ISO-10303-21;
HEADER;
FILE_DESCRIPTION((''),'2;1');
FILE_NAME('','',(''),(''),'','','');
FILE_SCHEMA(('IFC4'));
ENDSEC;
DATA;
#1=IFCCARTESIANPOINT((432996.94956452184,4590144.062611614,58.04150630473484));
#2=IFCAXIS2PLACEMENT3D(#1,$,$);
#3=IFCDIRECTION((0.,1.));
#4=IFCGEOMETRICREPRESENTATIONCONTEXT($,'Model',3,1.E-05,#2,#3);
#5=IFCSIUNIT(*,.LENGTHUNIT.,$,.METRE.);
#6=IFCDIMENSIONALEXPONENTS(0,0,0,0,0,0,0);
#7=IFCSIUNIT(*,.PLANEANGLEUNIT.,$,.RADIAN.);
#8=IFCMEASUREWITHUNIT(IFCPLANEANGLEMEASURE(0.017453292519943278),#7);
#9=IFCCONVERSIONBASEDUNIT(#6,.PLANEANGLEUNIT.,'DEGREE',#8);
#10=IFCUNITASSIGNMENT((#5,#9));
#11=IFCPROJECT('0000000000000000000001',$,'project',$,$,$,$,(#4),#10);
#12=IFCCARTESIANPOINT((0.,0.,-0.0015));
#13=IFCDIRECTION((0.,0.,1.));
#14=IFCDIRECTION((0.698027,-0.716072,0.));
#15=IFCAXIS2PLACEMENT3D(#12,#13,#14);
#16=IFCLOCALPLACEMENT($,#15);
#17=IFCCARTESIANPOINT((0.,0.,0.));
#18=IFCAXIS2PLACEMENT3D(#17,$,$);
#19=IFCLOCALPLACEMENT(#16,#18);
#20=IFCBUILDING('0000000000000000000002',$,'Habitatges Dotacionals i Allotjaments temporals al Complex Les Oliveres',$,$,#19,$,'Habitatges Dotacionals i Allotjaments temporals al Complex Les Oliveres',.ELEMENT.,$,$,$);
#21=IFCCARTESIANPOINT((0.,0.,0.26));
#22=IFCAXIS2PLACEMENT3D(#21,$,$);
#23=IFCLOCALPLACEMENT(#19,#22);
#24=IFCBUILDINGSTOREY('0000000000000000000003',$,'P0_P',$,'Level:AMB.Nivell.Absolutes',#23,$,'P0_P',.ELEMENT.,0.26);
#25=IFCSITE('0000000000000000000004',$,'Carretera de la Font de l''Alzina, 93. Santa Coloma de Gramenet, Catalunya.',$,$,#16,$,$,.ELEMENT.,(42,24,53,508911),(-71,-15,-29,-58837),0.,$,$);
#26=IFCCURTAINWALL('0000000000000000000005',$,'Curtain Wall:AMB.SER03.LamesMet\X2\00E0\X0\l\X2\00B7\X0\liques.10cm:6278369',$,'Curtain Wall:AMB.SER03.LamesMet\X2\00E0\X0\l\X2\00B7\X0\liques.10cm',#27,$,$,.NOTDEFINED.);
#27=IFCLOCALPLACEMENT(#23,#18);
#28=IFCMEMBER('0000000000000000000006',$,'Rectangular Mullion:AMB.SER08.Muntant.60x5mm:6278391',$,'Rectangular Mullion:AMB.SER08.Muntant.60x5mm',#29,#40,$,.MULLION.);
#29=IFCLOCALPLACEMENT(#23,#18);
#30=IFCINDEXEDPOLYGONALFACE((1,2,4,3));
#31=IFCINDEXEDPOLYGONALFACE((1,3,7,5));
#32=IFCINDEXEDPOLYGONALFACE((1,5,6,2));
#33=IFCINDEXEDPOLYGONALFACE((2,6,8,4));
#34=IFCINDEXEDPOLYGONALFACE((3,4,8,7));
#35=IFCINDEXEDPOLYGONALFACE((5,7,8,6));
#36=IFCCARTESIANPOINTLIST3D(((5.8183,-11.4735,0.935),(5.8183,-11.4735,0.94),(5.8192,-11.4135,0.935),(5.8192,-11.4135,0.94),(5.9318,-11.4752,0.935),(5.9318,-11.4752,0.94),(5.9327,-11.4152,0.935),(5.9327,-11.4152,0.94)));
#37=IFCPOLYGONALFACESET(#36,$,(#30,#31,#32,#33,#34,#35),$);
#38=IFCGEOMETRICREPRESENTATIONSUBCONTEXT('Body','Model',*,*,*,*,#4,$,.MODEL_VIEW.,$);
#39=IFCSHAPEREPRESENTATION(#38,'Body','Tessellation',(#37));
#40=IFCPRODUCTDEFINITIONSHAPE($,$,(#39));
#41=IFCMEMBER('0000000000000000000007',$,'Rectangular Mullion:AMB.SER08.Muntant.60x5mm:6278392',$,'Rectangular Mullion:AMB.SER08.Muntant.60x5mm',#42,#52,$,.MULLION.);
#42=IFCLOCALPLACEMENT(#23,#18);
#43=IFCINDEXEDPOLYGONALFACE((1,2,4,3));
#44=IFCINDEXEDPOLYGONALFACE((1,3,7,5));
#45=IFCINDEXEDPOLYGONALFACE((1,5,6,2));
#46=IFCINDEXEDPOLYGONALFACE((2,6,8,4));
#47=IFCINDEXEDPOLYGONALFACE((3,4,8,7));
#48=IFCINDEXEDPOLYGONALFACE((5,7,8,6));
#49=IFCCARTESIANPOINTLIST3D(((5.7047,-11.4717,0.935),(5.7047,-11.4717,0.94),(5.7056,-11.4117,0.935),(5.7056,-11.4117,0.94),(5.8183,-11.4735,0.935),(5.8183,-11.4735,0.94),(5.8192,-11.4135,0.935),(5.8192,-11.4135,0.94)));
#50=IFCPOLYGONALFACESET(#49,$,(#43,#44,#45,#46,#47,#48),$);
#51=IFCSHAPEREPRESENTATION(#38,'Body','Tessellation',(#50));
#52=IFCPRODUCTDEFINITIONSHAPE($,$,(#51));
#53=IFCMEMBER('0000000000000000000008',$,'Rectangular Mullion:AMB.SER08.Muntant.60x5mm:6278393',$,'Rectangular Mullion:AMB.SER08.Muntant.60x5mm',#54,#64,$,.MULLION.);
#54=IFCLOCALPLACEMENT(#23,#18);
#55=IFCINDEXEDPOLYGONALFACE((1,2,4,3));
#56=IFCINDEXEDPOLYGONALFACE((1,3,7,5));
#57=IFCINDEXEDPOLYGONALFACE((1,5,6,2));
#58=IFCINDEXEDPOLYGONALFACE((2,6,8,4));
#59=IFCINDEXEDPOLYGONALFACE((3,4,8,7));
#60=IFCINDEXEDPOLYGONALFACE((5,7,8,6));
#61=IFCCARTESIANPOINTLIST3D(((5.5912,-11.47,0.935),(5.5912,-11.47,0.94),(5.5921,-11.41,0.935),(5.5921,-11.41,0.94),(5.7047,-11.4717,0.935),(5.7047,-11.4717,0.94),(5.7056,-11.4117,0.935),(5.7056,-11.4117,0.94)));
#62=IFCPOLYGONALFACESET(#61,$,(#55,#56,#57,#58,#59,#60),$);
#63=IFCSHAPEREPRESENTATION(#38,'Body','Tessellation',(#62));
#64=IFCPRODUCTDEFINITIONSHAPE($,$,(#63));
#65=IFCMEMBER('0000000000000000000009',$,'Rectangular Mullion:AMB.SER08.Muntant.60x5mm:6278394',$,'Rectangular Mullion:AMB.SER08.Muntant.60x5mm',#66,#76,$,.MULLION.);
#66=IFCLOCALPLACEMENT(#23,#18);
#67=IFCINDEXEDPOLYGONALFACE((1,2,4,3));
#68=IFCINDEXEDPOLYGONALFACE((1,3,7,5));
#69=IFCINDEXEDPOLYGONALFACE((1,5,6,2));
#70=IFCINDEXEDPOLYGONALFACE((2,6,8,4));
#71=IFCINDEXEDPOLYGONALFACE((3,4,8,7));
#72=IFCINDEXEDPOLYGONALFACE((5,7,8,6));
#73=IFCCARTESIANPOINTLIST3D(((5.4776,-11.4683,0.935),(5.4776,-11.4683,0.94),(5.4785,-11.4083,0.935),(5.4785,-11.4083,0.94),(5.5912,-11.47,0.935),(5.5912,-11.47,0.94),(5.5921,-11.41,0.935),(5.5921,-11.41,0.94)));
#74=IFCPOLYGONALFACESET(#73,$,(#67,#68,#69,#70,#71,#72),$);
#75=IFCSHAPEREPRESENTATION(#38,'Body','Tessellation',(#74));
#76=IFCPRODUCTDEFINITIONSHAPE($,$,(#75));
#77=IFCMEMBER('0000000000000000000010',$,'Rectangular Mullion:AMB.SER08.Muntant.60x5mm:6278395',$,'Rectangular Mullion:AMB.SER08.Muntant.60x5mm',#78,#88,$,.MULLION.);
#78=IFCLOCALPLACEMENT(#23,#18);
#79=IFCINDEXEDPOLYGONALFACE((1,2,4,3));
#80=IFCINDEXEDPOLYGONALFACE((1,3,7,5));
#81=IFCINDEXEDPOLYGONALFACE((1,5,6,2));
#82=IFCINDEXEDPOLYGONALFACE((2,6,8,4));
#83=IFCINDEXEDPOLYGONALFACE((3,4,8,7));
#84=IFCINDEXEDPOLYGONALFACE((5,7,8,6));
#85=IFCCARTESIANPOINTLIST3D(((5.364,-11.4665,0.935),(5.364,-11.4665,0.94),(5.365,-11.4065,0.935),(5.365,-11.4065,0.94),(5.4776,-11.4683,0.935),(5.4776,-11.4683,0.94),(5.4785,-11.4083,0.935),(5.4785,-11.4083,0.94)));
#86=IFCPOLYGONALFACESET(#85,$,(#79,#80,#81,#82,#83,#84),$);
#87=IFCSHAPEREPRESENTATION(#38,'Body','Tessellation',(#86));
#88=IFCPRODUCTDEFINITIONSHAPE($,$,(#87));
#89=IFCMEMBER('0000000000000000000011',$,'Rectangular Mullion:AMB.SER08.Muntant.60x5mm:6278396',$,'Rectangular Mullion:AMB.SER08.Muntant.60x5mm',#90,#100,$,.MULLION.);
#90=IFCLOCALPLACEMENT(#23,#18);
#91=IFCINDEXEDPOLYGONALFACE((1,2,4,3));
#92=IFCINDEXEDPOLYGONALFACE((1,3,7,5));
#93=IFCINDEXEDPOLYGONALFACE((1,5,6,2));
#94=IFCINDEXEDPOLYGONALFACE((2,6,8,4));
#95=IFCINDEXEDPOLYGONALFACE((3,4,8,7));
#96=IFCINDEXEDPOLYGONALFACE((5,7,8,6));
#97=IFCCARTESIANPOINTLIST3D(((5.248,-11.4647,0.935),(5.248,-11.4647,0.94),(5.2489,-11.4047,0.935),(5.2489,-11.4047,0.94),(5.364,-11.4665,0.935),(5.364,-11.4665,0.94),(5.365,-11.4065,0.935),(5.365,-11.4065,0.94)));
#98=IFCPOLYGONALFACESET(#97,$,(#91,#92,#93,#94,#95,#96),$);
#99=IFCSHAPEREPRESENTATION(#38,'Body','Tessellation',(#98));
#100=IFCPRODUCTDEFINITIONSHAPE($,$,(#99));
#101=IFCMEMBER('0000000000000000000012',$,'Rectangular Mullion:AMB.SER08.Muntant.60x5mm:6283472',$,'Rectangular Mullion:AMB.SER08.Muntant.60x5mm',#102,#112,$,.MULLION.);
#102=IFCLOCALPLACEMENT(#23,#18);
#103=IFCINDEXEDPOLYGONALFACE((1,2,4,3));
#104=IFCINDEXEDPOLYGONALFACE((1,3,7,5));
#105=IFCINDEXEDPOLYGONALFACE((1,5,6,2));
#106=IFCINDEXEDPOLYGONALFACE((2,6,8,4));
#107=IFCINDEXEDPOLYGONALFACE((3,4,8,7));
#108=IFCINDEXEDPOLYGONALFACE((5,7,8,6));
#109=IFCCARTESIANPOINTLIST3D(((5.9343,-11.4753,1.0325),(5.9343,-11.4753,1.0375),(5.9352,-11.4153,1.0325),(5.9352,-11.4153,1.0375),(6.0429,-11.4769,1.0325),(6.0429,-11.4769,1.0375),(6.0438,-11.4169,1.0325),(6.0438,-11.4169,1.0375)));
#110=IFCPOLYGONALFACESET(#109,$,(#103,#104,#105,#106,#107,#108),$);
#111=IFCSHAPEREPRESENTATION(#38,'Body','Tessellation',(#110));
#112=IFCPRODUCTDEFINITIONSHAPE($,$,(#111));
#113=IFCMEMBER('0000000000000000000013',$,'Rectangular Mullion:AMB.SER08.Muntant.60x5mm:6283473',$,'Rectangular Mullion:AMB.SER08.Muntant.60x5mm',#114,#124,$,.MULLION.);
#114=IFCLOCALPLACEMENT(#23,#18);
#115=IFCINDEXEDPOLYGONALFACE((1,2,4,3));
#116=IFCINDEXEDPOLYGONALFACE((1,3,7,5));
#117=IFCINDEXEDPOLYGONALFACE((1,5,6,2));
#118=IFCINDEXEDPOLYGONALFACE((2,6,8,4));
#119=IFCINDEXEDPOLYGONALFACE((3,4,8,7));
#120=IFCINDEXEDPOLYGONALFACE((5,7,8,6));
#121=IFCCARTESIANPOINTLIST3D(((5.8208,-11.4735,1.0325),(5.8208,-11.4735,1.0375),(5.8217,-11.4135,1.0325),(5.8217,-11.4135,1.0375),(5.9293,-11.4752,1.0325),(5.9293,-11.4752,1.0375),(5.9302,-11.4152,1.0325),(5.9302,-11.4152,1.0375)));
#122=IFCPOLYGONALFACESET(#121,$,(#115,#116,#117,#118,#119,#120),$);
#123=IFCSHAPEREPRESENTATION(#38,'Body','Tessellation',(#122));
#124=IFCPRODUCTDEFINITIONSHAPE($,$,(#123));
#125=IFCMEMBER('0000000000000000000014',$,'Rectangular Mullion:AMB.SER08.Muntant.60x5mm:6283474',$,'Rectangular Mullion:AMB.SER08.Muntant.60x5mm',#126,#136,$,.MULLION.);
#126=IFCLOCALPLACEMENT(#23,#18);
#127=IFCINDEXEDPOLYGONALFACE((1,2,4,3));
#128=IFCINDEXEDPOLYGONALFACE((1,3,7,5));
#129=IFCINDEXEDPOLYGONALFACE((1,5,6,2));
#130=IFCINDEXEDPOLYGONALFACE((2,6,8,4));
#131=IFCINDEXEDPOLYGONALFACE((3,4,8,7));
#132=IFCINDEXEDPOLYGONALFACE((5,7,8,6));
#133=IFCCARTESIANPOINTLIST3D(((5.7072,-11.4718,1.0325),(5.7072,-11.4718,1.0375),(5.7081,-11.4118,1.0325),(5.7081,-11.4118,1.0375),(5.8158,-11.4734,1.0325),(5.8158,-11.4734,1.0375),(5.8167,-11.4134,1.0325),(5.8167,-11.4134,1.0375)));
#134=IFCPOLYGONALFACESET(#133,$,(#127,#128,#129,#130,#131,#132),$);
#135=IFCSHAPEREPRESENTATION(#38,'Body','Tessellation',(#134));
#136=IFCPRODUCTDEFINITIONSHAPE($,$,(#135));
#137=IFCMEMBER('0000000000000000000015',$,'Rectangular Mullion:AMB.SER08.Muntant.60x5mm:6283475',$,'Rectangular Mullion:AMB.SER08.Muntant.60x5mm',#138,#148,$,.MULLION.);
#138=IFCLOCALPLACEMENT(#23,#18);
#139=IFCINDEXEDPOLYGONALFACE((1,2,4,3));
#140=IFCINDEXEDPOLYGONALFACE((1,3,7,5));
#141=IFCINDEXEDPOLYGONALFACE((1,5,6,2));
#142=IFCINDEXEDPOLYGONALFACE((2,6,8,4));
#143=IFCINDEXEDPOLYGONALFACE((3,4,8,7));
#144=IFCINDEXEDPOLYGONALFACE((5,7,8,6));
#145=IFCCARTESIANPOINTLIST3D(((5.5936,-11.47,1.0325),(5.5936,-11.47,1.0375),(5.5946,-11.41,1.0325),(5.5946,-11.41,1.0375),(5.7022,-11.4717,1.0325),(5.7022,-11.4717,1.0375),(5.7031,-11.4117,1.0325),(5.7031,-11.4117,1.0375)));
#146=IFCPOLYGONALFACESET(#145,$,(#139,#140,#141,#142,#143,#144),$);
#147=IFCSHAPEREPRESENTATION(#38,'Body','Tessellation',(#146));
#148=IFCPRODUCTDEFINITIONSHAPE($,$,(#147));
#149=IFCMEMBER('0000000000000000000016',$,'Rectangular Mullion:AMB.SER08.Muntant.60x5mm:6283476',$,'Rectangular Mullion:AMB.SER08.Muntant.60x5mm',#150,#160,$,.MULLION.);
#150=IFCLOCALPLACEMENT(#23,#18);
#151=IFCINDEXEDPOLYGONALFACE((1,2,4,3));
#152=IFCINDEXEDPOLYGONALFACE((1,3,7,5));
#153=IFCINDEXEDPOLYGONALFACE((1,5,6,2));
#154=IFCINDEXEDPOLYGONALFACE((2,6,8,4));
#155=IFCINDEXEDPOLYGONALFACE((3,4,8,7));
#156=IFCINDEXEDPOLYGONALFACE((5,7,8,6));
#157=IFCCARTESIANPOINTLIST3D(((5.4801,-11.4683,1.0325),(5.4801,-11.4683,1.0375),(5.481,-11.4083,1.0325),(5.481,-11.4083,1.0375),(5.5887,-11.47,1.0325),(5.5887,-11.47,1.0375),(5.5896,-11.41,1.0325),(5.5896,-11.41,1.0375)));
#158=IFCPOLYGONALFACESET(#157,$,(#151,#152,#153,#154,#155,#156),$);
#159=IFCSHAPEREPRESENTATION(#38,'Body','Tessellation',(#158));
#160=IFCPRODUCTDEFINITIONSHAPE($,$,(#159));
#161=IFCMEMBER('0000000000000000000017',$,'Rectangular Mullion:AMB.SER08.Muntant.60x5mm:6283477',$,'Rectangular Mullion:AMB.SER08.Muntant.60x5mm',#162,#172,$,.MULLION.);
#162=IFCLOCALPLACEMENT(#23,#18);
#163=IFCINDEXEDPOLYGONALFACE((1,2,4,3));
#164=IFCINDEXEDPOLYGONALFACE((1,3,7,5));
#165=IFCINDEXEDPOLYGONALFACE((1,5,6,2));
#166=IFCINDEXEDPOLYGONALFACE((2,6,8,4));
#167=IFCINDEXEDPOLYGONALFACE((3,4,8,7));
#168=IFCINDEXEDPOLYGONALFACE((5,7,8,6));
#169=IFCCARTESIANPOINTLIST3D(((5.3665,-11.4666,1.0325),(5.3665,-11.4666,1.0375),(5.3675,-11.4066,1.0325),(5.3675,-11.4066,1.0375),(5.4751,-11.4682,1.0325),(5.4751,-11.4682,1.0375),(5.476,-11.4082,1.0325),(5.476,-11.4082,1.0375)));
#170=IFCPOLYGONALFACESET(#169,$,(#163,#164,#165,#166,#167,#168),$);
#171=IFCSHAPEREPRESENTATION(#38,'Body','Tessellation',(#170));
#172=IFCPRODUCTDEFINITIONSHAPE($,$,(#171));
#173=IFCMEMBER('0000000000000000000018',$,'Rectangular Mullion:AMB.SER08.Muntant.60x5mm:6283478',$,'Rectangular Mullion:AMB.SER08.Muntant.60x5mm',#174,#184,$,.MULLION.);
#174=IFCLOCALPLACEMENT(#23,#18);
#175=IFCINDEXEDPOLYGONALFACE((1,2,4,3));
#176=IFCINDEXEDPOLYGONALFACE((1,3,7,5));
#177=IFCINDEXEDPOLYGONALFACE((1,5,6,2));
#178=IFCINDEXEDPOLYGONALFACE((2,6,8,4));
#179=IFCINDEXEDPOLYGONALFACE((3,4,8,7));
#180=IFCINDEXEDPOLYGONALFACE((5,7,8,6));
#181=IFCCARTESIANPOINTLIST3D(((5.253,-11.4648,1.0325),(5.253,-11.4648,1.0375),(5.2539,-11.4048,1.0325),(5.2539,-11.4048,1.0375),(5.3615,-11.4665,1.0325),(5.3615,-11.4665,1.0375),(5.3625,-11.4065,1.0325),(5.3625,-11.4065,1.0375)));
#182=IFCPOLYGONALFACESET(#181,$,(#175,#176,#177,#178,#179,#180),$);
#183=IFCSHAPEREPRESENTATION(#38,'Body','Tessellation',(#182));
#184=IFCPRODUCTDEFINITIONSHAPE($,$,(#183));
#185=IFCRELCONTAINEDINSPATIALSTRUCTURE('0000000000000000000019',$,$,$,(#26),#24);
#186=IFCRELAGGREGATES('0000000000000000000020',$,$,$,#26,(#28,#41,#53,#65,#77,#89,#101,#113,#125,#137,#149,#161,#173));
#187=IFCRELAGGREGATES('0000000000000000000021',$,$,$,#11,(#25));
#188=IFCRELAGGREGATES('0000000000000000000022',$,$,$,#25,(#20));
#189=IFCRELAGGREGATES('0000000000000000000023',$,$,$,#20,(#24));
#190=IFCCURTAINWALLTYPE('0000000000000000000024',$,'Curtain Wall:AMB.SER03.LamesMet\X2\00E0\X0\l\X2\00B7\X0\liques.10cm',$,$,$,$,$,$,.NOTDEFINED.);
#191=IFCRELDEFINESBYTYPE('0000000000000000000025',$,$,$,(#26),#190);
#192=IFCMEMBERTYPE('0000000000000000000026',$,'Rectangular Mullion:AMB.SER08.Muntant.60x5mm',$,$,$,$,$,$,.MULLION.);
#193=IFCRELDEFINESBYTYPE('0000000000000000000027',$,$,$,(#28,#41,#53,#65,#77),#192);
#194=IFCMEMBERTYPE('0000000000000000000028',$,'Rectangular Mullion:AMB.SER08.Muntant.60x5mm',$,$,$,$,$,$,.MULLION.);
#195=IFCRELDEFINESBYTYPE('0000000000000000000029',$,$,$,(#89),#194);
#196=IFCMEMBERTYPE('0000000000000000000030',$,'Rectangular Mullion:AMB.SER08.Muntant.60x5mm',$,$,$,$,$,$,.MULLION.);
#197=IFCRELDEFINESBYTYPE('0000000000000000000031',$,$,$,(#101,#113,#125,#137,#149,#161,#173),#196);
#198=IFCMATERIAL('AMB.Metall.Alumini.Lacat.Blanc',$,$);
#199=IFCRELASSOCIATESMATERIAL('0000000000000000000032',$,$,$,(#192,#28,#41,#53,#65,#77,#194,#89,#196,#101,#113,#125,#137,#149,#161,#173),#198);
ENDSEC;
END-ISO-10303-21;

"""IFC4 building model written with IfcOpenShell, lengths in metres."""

from ifc_helpers import new_model, entity, si_unit, converted_unit, direction, frame, origin, place, context, subcontext, project, spatial, indexed_curve, outline, extrude, source, transform, mapped, material, type_object, type_shapes, element, aggregate, save


model = new_model("IFC4")

# Units and contexts
model_context = context("Model", 3, precision=1e-05, world=frame((432996.94956452184, 4590144.062611614, 58.04150630473484)), true_north=direction((0.0, 1.0)))
body_context = subcontext(model_context, "Body", "Model", "MODEL_VIEW")
ifc_project = project(units=[si_unit("LENGTHUNIT", "METRE"), converted_unit("PLANEANGLEUNIT", "DEGREE", entity("IfcPlaneAngleMeasure", 0.017453292519943278), si_unit("PLANEANGLEUNIT", "RADIAN"), dimensions=[0, 0, 0, 0, 0, 0, 0])], contexts=[model_context])

# Site, building, storey
site_placement = place(None, frame((0.0, 0.0, -0.0015), z_axis=(0.0, 0.0, 1.0), x_axis=(0.698027, -0.716072, 0.0)))
site = spatial("IfcSite", under=ifc_project, at=site_placement, Name="Carretera de la Font de l'Alzina, 93. Santa Coloma de Gramenet, Catalunya.", CompositionType="ELEMENT", RefLatitude=(42, 24, 53, 508911), RefLongitude=(-71, -15, -29, -58837), RefElevation=0.0)
building_placement = place(site_placement, origin())
building = spatial("IfcBuilding", under=site, at=building_placement, Name="Habitatges Dotacionals i Allotjaments temporals al Complex Les Oliveres", LongName="Habitatges Dotacionals i Allotjaments temporals al Complex Les Oliveres", CompositionType="ELEMENT")
storey_placement = place(building_placement, frame((0.0, 0.0, 0.26)))
storey = spatial("IfcBuildingStorey", under=building, at=storey_placement, Name="P0_P", ObjectType="Level:AMB.Nivell.Absolutes", LongName="P0_P", CompositionType="ELEMENT", Elevation=0.26)

# Shared definitions
curtain_wall_type = type_object("IfcCurtainWallType", Name="Curtain Wall:AMB.SER03.LamesMetàl·liques.10cm", PredefinedType="NOTDEFINED")
ifc_material_1 = material(Name="AMB.Metall.Alumini.Lacat.Blanc")

# Curtain wall
curtain_wall_1_placement = place(storey_placement, frame((0.0, 0.0, -0.26)))
curtain_wall_1 = element("IfcCurtainWall", 1, at=curtain_wall_1_placement, inside=storey, type_object=curtain_wall_type, Name="Curtain Wall:AMB.SER03.LamesMetàl·liques.10cm:6278369", ObjectType="Curtain Wall:AMB.SER03.LamesMetàl·liques.10cm", PredefinedType="NOTDEFINED")

# Members
member_type_1 = type_object("IfcMemberType", Name="Rectangular Mullion:AMB.SER08.Muntant.60x5mm", PredefinedType="MULLION", material=ifc_material_1)
shared_shape_1 = source(origin(), body_context, "Body", "SweptSolid", [
    extrude(outline(indexed_curve([(-0.0025, -0.03), (0.0025, -0.03), (0.0025, 0.03), (-0.0025, 0.03), (-0.0025, -0.03)], self_intersect=False)), frame((-0.0025, 0.03, -0.1136), z_axis=(0.0, 0.0, 1.0), x_axis=(-1.0, 0.0, 0.0)), (0.0, 0.0, 1.0), 0.1136),
])
type_shapes(member_type_1, [shared_shape_1])
member_1_placement = place(curtain_wall_1_placement, frame((5.9318, -11.4752, 1.195), z_axis=(0.999883, -0.015319, 0.0), x_axis=(0.0, 0.0, -1.0)))
member_1 = element("IfcMember", 2, at=member_1_placement, type_object=member_type_1, material=ifc_material_1, Name="Rectangular Mullion:AMB.SER08.Muntant.60x5mm:6278391", ObjectType="Rectangular Mullion:AMB.SER08.Muntant.60x5mm", PredefinedType="MULLION", context=body_context, shape_type="MappedRepresentation", body=[
    mapped(shared_shape_1, transform((0.0, 0.0, 0.0), scale=1.0)),
])
member_2_placement = place(curtain_wall_1_placement, frame((5.8183, -11.4735, 1.195), z_axis=(0.999883, -0.015319, 0.0), x_axis=(0.0, 0.0, -1.0)))
member_2 = element("IfcMember", 3, at=member_2_placement, type_object=member_type_1, material=ifc_material_1, Name="Rectangular Mullion:AMB.SER08.Muntant.60x5mm:6278392", ObjectType="Rectangular Mullion:AMB.SER08.Muntant.60x5mm", PredefinedType="MULLION", context=body_context, shape_type="MappedRepresentation", body=[
    mapped(shared_shape_1, transform((0.0, 0.0, 0.0), scale=1.0)),
])
member_3_placement = place(curtain_wall_1_placement, frame((5.7047, -11.4717, 1.195), z_axis=(0.999883, -0.015319, 0.0), x_axis=(0.0, 0.0, -1.0)))
member_3 = element("IfcMember", 4, at=member_3_placement, type_object=member_type_1, material=ifc_material_1, Name="Rectangular Mullion:AMB.SER08.Muntant.60x5mm:6278393", ObjectType="Rectangular Mullion:AMB.SER08.Muntant.60x5mm", PredefinedType="MULLION", context=body_context, shape_type="MappedRepresentation", body=[
    mapped(shared_shape_1, transform((0.0, 0.0, 0.0), scale=1.0)),
])
member_4_placement = place(curtain_wall_1_placement, frame((5.5912, -11.47, 1.195), z_axis=(0.999883, -0.015319, 0.0), x_axis=(0.0, 0.0, -1.0)))
member_4 = element("IfcMember", 5, at=member_4_placement, type_object=member_type_1, material=ifc_material_1, Name="Rectangular Mullion:AMB.SER08.Muntant.60x5mm:6278394", ObjectType="Rectangular Mullion:AMB.SER08.Muntant.60x5mm", PredefinedType="MULLION", context=body_context, shape_type="MappedRepresentation", body=[
    mapped(shared_shape_1, transform((0.0, 0.0, 0.0), scale=1.0)),
])
member_5_placement = place(curtain_wall_1_placement, frame((5.4776, -11.4683, 1.195), z_axis=(0.999883, -0.015319, 0.0), x_axis=(0.0, 0.0, -1.0)))
member_5 = element("IfcMember", 6, at=member_5_placement, type_object=member_type_1, material=ifc_material_1, Name="Rectangular Mullion:AMB.SER08.Muntant.60x5mm:6278395", ObjectType="Rectangular Mullion:AMB.SER08.Muntant.60x5mm", PredefinedType="MULLION", context=body_context, shape_type="MappedRepresentation", body=[
    mapped(shared_shape_1, transform((0.0, 0.0, 0.0), scale=1.0)),
])
member_type_2 = type_object("IfcMemberType", Name="Rectangular Mullion:AMB.SER08.Muntant.60x5mm", PredefinedType="MULLION", material=ifc_material_1)
shared_shape_2 = source(origin(), body_context, "Body", "SweptSolid", [
    extrude(outline(indexed_curve([(-0.0025, -0.03), (0.0025, -0.03), (0.0025, 0.03), (-0.0025, 0.03), (-0.0025, -0.03)], self_intersect=False)), frame((-0.0025, 0.03, -0.1161), z_axis=(0.0, 0.0, 1.0), x_axis=(-1.0, 0.0, 0.0)), (0.0, 0.0, 1.0), 0.1161),
])
type_shapes(member_type_2, [shared_shape_2])
member_6_placement = place(curtain_wall_1_placement, frame((5.364, -11.4665, 1.195), z_axis=(0.999883, -0.015319, 0.0), x_axis=(0.0, 0.0, -1.0)))
member_6 = element("IfcMember", 7, at=member_6_placement, type_object=member_type_2, material=ifc_material_1, Name="Rectangular Mullion:AMB.SER08.Muntant.60x5mm:6278396", ObjectType="Rectangular Mullion:AMB.SER08.Muntant.60x5mm", PredefinedType="MULLION", context=body_context, shape_type="MappedRepresentation", body=[
    mapped(shared_shape_2, transform((0.0, 0.0, 0.0), scale=1.0)),
])
member_type_3 = type_object("IfcMemberType", Name="Rectangular Mullion:AMB.SER08.Muntant.60x5mm", PredefinedType="MULLION", material=ifc_material_1)
shared_shape_3 = source(origin(), body_context, "Body", "SweptSolid", [
    extrude(outline(indexed_curve([(-0.0025, -0.03), (0.0025, -0.03), (0.0025, 0.03), (-0.0025, 0.03), (-0.0025, -0.03)], self_intersect=False)), frame((0.0, 0.03, -0.1086), z_axis=(0.0, 0.0, 1.0), x_axis=(-1.0, 0.0, 0.0)), (0.0, 0.0, 1.0), 0.1086),
])
type_shapes(member_type_3, [shared_shape_3])
member_7_placement = place(curtain_wall_1_placement, frame((5.9343, -11.4753, 1.295), z_axis=(-0.999883, 0.015319, 0.0), x_axis=(0.0, 0.0, 1.0)))
member_7 = element("IfcMember", 8, at=member_7_placement, type_object=member_type_3, material=ifc_material_1, Name="Rectangular Mullion:AMB.SER08.Muntant.60x5mm:6283472", ObjectType="Rectangular Mullion:AMB.SER08.Muntant.60x5mm", PredefinedType="MULLION", context=body_context, shape_type="MappedRepresentation", body=[
    mapped(shared_shape_3, transform((0.0, 0.0, 0.0), scale=1.0)),
])
member_8_placement = place(curtain_wall_1_placement, frame((5.8208, -11.4735, 1.295), z_axis=(-0.999883, 0.015319, 0.0), x_axis=(0.0, 0.0, 1.0)))
member_8 = element("IfcMember", 9, at=member_8_placement, type_object=member_type_3, material=ifc_material_1, Name="Rectangular Mullion:AMB.SER08.Muntant.60x5mm:6283473", ObjectType="Rectangular Mullion:AMB.SER08.Muntant.60x5mm", PredefinedType="MULLION", context=body_context, shape_type="MappedRepresentation", body=[
    mapped(shared_shape_3, transform((0.0, 0.0, 0.0), scale=1.0)),
])
member_9_placement = place(curtain_wall_1_placement, frame((5.7072, -11.4718, 1.295), z_axis=(-0.999883, 0.015319, 0.0), x_axis=(0.0, 0.0, 1.0)))
member_9 = element("IfcMember", 10, at=member_9_placement, type_object=member_type_3, material=ifc_material_1, Name="Rectangular Mullion:AMB.SER08.Muntant.60x5mm:6283474", ObjectType="Rectangular Mullion:AMB.SER08.Muntant.60x5mm", PredefinedType="MULLION", context=body_context, shape_type="MappedRepresentation", body=[
    mapped(shared_shape_3, transform((0.0, 0.0, 0.0), scale=1.0)),
])
member_10_placement = place(curtain_wall_1_placement, frame((5.5936, -11.47, 1.295), z_axis=(-0.999883, 0.015319, 0.0), x_axis=(0.0, 0.0, 1.0)))
member_10 = element("IfcMember", 11, at=member_10_placement, type_object=member_type_3, material=ifc_material_1, Name="Rectangular Mullion:AMB.SER08.Muntant.60x5mm:6283475", ObjectType="Rectangular Mullion:AMB.SER08.Muntant.60x5mm", PredefinedType="MULLION", context=body_context, shape_type="MappedRepresentation", body=[
    mapped(shared_shape_3, transform((0.0, 0.0, 0.0), scale=1.0)),
])
member_11_placement = place(curtain_wall_1_placement, frame((5.4801, -11.4683, 1.295), z_axis=(-0.999883, 0.015319, 0.0), x_axis=(0.0, 0.0, 1.0)))
member_11 = element("IfcMember", 12, at=member_11_placement, type_object=member_type_3, material=ifc_material_1, Name="Rectangular Mullion:AMB.SER08.Muntant.60x5mm:6283476", ObjectType="Rectangular Mullion:AMB.SER08.Muntant.60x5mm", PredefinedType="MULLION", context=body_context, shape_type="MappedRepresentation", body=[
    mapped(shared_shape_3, transform((0.0, 0.0, 0.0), scale=1.0)),
])
member_12_placement = place(curtain_wall_1_placement, frame((5.3665, -11.4666, 1.295), z_axis=(-0.999883, 0.015319, 0.0), x_axis=(0.0, 0.0, 1.0)))
member_12 = element("IfcMember", 13, at=member_12_placement, type_object=member_type_3, material=ifc_material_1, Name="Rectangular Mullion:AMB.SER08.Muntant.60x5mm:6283477", ObjectType="Rectangular Mullion:AMB.SER08.Muntant.60x5mm", PredefinedType="MULLION", context=body_context, shape_type="MappedRepresentation", body=[
    mapped(shared_shape_3, transform((0.0, 0.0, 0.0), scale=1.0)),
])
member_13_placement = place(curtain_wall_1_placement, frame((5.253, -11.4648, 1.295), z_axis=(-0.999883, 0.015319, 0.0), x_axis=(0.0, 0.0, 1.0)))
member_13 = element("IfcMember", 14, at=member_13_placement, type_object=member_type_3, material=ifc_material_1, Name="Rectangular Mullion:AMB.SER08.Muntant.60x5mm:6283478", ObjectType="Rectangular Mullion:AMB.SER08.Muntant.60x5mm", PredefinedType="MULLION", context=body_context, shape_type="MappedRepresentation", body=[
    mapped(shared_shape_3, transform((0.0, 0.0, 0.0), scale=1.0)),
])
aggregate(curtain_wall_1, [member_1, member_2, member_3, member_4, member_5, member_6, member_7, member_8, member_9, member_10, member_11, member_12, member_13])

save(model, "model.ifc")
